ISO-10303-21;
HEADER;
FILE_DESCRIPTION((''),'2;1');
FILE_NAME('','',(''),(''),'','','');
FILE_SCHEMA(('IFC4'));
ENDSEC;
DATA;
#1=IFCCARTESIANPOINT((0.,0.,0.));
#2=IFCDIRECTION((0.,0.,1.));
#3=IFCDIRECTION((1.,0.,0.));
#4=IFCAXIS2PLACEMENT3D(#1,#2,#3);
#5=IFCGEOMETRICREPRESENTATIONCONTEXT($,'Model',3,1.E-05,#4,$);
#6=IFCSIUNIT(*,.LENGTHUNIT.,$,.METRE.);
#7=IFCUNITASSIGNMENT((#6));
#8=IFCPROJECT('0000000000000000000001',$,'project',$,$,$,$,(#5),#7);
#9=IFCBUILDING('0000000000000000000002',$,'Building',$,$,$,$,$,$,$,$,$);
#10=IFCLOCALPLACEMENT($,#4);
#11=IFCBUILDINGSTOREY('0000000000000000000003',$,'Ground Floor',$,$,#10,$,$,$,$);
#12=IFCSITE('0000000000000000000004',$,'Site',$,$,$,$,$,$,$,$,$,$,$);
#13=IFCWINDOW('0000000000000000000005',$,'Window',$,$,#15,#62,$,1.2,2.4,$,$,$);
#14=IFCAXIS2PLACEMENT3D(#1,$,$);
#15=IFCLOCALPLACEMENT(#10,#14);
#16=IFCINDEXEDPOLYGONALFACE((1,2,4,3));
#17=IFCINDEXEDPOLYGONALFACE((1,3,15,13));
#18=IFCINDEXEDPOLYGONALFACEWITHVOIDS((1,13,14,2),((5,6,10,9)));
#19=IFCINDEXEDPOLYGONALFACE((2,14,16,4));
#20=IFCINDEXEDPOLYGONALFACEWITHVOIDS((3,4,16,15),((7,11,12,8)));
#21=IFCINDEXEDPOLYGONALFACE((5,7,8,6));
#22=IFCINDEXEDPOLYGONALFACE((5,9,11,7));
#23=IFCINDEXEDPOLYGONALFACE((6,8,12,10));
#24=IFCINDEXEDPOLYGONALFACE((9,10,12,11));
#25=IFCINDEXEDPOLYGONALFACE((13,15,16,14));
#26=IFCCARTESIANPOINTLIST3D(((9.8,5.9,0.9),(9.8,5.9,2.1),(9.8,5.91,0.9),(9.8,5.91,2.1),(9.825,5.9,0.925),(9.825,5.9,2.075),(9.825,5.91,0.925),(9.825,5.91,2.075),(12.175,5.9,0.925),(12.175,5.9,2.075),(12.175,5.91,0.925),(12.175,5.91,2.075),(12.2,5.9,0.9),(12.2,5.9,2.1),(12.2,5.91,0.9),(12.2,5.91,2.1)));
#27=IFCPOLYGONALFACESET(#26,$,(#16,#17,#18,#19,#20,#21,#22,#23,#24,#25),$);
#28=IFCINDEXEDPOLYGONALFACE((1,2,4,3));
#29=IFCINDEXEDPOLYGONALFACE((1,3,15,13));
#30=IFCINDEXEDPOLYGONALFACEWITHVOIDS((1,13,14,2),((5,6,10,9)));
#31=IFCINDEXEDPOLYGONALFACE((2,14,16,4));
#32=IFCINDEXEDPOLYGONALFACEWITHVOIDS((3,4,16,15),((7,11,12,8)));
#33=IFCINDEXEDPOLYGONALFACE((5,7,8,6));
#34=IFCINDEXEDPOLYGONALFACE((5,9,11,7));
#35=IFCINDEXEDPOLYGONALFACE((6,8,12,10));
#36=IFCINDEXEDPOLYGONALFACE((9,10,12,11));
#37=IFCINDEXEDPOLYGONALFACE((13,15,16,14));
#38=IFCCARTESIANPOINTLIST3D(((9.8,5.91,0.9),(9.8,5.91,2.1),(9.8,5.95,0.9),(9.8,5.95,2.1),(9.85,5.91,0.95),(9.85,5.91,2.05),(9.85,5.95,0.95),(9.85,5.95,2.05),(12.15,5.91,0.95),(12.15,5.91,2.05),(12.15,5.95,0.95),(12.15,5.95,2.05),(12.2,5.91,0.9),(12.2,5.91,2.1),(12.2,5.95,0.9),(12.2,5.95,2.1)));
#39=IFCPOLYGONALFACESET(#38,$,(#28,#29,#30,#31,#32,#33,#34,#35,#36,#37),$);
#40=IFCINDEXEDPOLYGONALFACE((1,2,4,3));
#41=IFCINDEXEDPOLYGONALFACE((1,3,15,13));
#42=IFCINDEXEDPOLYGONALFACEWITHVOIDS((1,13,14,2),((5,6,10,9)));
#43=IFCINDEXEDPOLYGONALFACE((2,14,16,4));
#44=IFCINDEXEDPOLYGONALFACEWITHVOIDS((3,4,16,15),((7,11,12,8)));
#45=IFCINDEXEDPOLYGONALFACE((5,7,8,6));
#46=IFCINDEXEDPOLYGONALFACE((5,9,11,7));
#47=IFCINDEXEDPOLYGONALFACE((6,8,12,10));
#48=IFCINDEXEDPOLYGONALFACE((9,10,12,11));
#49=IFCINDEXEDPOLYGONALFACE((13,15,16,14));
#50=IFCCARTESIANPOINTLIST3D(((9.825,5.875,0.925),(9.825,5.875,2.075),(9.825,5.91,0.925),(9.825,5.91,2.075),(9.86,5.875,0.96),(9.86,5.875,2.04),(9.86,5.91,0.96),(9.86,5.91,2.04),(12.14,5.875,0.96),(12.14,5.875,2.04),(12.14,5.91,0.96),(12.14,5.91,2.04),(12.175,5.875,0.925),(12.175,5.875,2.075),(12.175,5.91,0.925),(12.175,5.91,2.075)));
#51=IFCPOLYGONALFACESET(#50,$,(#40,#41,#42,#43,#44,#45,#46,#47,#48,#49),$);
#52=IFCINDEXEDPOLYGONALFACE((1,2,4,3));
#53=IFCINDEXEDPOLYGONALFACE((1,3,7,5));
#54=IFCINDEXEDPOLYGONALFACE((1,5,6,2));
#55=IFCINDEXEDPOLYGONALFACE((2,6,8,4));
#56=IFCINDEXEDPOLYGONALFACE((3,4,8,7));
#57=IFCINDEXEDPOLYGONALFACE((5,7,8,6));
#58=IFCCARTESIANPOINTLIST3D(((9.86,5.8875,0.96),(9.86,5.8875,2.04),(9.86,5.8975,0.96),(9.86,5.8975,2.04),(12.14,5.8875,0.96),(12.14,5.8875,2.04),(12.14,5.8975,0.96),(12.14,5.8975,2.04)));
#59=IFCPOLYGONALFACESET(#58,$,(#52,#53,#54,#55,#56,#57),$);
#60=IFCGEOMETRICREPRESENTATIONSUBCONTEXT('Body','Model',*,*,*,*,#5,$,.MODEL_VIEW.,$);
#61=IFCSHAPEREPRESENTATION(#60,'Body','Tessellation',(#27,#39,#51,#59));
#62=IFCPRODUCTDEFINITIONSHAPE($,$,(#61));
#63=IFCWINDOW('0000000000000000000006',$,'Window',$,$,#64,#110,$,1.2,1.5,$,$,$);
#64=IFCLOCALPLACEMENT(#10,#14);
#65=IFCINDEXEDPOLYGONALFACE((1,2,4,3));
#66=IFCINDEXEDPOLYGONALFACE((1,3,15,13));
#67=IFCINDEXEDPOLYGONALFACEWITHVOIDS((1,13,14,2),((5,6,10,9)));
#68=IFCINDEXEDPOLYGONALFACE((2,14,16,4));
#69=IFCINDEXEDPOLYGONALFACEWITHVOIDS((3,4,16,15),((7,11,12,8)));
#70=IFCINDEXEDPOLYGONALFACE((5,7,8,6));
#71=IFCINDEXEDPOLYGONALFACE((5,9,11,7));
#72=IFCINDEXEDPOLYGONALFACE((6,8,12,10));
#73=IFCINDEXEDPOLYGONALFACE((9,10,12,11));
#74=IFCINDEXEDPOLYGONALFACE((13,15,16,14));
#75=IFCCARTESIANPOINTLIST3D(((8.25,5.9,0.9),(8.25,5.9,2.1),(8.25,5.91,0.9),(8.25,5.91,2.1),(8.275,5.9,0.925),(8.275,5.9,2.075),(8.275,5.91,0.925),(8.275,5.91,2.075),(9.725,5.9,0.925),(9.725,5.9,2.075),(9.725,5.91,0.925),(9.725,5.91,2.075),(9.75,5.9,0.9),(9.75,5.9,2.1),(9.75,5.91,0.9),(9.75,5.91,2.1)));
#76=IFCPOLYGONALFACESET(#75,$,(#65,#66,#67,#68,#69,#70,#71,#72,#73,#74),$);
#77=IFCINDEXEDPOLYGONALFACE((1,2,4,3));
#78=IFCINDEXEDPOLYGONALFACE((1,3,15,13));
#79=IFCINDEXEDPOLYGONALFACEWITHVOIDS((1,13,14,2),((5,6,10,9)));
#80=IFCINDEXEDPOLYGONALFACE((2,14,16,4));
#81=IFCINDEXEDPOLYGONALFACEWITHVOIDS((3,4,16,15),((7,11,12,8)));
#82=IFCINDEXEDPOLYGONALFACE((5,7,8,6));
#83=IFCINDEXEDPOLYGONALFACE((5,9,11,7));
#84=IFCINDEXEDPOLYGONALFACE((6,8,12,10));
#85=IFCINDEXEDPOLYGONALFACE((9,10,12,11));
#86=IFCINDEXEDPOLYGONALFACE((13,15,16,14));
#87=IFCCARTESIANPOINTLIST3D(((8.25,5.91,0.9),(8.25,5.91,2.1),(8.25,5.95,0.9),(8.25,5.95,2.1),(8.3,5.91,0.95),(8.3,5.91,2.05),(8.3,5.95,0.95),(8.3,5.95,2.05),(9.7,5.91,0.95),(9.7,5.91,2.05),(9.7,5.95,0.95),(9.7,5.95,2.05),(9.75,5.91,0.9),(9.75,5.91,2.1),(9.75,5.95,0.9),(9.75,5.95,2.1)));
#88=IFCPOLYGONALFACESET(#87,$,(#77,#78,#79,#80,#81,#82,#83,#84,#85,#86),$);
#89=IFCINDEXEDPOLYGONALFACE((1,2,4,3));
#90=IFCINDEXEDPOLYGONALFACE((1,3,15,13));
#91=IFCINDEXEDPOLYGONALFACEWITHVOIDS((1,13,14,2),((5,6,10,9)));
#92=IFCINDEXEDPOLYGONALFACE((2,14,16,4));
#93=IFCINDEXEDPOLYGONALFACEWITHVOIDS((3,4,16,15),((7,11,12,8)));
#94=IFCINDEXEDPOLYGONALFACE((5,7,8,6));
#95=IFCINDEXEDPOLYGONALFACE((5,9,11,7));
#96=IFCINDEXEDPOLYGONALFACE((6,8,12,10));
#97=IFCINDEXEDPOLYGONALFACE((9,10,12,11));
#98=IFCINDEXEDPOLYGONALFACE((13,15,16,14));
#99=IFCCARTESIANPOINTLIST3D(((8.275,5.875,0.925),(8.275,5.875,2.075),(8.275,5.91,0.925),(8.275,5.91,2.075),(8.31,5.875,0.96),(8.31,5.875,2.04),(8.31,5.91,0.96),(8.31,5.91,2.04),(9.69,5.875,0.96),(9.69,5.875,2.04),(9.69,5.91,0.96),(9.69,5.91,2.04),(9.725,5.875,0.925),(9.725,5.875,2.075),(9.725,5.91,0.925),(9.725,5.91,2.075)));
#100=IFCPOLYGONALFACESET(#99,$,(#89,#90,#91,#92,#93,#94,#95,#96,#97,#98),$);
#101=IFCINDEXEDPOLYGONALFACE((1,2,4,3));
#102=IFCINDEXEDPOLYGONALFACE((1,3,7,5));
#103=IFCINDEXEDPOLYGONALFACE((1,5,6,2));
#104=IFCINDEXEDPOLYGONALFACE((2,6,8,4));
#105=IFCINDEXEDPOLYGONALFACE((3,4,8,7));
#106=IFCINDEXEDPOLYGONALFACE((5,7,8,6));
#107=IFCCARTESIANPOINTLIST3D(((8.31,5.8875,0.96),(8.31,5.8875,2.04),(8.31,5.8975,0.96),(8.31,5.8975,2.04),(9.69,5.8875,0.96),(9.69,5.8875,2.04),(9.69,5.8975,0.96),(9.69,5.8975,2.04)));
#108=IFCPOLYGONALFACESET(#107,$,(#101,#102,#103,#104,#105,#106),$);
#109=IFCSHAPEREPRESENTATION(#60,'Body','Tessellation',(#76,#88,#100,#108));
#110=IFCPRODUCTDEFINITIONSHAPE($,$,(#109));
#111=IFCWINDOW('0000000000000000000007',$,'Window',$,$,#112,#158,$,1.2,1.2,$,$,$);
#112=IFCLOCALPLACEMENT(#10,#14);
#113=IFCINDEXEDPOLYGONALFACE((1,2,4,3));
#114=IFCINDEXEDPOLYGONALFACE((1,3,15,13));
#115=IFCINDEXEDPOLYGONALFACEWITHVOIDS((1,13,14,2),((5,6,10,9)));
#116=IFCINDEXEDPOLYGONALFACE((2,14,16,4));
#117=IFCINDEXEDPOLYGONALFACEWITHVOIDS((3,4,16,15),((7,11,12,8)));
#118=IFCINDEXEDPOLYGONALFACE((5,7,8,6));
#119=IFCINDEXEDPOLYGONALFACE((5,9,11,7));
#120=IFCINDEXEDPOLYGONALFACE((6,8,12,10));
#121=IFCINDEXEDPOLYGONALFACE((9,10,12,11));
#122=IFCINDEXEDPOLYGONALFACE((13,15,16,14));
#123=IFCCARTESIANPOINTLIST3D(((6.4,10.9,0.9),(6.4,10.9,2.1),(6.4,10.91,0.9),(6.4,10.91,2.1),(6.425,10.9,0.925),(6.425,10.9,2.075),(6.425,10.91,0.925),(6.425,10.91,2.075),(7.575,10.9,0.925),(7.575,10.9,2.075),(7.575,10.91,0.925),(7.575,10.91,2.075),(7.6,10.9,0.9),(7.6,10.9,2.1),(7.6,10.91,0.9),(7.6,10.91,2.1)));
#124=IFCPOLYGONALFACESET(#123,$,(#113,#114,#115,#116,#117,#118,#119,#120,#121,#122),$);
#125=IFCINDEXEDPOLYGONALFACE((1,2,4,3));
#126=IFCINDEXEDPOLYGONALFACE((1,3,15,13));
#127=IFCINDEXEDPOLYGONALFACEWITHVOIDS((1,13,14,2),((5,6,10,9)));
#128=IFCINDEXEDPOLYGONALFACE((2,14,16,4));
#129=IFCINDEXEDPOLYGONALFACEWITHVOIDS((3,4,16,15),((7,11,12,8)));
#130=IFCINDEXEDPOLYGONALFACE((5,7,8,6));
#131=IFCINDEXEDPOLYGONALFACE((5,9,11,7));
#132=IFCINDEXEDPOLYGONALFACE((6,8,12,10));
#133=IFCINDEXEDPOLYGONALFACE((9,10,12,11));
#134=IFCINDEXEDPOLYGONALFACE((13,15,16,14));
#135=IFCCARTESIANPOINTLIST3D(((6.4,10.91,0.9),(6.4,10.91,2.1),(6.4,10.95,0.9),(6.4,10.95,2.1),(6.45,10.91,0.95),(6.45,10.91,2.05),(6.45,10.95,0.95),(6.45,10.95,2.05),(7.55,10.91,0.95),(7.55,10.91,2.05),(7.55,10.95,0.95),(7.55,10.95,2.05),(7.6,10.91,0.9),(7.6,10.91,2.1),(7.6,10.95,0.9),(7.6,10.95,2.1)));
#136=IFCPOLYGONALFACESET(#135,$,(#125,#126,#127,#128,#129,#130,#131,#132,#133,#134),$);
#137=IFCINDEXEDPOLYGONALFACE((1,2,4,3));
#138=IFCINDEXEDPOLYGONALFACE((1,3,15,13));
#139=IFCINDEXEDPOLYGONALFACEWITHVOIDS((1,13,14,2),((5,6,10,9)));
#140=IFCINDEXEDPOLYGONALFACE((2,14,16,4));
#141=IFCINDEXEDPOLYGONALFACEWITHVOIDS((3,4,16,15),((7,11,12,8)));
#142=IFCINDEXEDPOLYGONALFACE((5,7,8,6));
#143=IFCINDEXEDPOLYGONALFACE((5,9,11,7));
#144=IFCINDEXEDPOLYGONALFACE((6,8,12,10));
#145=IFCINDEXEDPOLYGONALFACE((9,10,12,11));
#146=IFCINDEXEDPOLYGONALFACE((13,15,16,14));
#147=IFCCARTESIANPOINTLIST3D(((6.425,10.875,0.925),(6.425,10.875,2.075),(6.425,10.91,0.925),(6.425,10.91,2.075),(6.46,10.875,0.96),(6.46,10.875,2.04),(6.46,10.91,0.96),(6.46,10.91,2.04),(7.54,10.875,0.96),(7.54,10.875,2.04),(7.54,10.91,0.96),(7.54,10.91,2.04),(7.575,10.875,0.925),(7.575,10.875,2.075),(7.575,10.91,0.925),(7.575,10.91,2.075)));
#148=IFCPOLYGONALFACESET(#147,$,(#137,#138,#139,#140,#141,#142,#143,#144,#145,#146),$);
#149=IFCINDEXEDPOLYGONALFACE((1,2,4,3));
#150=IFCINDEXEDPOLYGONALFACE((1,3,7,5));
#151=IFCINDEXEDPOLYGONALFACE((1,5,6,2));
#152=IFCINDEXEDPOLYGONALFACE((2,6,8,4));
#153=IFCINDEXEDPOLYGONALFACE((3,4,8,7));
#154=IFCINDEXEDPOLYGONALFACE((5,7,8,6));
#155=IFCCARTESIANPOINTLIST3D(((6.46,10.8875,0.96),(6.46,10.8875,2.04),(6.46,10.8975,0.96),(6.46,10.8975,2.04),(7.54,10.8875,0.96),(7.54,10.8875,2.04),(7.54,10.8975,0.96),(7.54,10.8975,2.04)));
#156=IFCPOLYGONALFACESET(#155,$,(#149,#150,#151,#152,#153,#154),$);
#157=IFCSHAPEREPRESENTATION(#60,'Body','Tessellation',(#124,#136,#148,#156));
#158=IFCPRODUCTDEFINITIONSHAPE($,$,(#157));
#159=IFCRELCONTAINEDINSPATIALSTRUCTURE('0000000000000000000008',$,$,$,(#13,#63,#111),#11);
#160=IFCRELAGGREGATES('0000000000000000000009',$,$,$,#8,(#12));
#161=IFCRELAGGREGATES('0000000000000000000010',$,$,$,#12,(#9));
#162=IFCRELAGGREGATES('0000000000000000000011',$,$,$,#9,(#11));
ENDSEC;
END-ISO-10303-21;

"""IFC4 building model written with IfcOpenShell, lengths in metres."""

from ifc_helpers import new_model, si_unit, frame, origin_with_axes, place, context, subcontext, project, spatial, line, indexed_curve, outline, extrude, element, save


model = new_model("IFC4")

# Units and contexts
model_context = context("Model", 3, precision=1e-05, world=origin_with_axes())
body_context = subcontext(model_context, "Body", "Model", "MODEL_VIEW")
ifc_project = project(units=[si_unit("LENGTHUNIT", "METRE")], contexts=[model_context])

# Site, building, storey
site = spatial("IfcSite", under=ifc_project, Name="Site")
building = spatial("IfcBuilding", under=site, Name="Building")
storey_placement = place(None, origin_with_axes())
storey = spatial("IfcBuildingStorey", under=building, at=storey_placement, Name="Ground Floor")

# Windows
window_1_placement = place(storey_placement, frame((12.2, 6.0, 0.9), z_axis=(0.0, 0.0, 1.0), x_axis=(-1.0, 0.0, 0.0)))
element("IfcWindow", 1, at=window_1_placement, inside=storey, Name="Window", OverallHeight=1.2, OverallWidth=2.4, context=body_context, shape_type="SweptSolid", body=[
    extrude(outline(indexed_curve([(0.0, 0.0), (2.4, 0.0), (2.4, 1.2), (0.0, 1.2)], segments=[line(1, 2, 3, 4, 1)]), holes=[indexed_curve([(0.025, 0.025), (2.375, 0.025), (2.375, 1.175), (0.025, 1.175)], segments=[line(1, 2, 3, 4, 1)])]), frame((0.0, 0.09, 0.0), z_axis=(0.0, -1.0, 0.0), x_axis=(1.0, 0.0, 0.0)), (0.0, 0.0, -1.0), 0.01),
    extrude(outline(indexed_curve([(0.0, 0.0), (2.4, 0.0), (2.4, 1.2), (0.0, 1.2)], segments=[line(1, 2, 3, 4, 1)]), holes=[indexed_curve([(0.05, 0.05), (2.35, 0.05), (2.35, 1.15), (0.05, 1.15)], segments=[line(1, 2, 3, 4, 1)])]), frame((0.0, 0.05, 0.0), z_axis=(0.0, -1.0, 0.0), x_axis=(1.0, 0.0, 0.0)), (0.0, 0.0, -1.0), 0.04),
    extrude(outline(indexed_curve([(0.0, 0.0), (2.35, 0.0), (2.35, 1.15), (0.0, 1.15)], segments=[line(1, 2, 3, 4, 1)]), holes=[indexed_curve([(0.035, 0.035), (2.315, 0.035), (2.315, 1.115), (0.035, 1.115)], segments=[line(1, 2, 3, 4, 1)])]), frame((0.025, 0.09, 0.025), z_axis=(0.0, -1.0, 0.0), x_axis=(1.0, 0.0, 0.0)), (0.0, 0.0, -1.0), 0.035),
    extrude(outline(indexed_curve([(0.035, 0.035), (2.315, 0.035), (2.315, 1.115), (0.035, 1.115)], segments=[line(1, 2, 3, 4, 1)])), frame((0.025, 0.1025, 0.025), z_axis=(0.0, -1.0, 0.0), x_axis=(1.0, 0.0, 0.0)), (0.0, 0.0, -1.0), 0.01),
])
window_2_placement = place(storey_placement, frame((9.75, 6.0, 0.9), z_axis=(0.0, 0.0, 1.0), x_axis=(-1.0, 0.0, 0.0)))
element("IfcWindow", 2, at=window_2_placement, inside=storey, Name="Window", OverallHeight=1.2, OverallWidth=1.5, context=body_context, shape_type="SweptSolid", body=[
    extrude(outline(indexed_curve([(0.0, 0.0), (1.5, 0.0), (1.5, 1.2), (0.0, 1.2)], segments=[line(1, 2, 3, 4, 1)]), holes=[indexed_curve([(0.025, 0.025), (1.475, 0.025), (1.475, 1.175), (0.025, 1.175)], segments=[line(1, 2, 3, 4, 1)])]), frame((0.0, 0.09, 0.0), z_axis=(0.0, -1.0, 0.0), x_axis=(1.0, 0.0, 0.0)), (0.0, 0.0, -1.0), 0.01),
    extrude(outline(indexed_curve([(0.0, 0.0), (1.5, 0.0), (1.5, 1.2), (0.0, 1.2)], segments=[line(1, 2, 3, 4, 1)]), holes=[indexed_curve([(0.05, 0.05), (1.45, 0.05), (1.45, 1.15), (0.05, 1.15)], segments=[line(1, 2, 3, 4, 1)])]), frame((0.0, 0.05, 0.0), z_axis=(0.0, -1.0, 0.0), x_axis=(1.0, 0.0, 0.0)), (0.0, 0.0, -1.0), 0.04),
    extrude(outline(indexed_curve([(0.0, 0.0), (1.45, 0.0), (1.45, 1.15), (0.0, 1.15)], segments=[line(1, 2, 3, 4, 1)]), holes=[indexed_curve([(0.035, 0.035), (1.415, 0.035), (1.415, 1.115), (0.035, 1.115)], segments=[line(1, 2, 3, 4, 1)])]), frame((0.025, 0.09, 0.025), z_axis=(0.0, -1.0, 0.0), x_axis=(1.0, 0.0, 0.0)), (0.0, 0.0, -1.0), 0.035),
    extrude(outline(indexed_curve([(0.035, 0.035), (1.415, 0.035), (1.415, 1.115), (0.035, 1.115)], segments=[line(1, 2, 3, 4, 1)])), frame((0.025, 0.1025, 0.025), z_axis=(0.0, -1.0, 0.0), x_axis=(1.0, 0.0, 0.0)), (0.0, 0.0, -1.0), 0.01),
])
window_3_placement = place(storey_placement, frame((7.6, 11.0, 0.9), z_axis=(0.0, 0.0, 1.0), x_axis=(-1.0, 0.0, 0.0)))
element("IfcWindow", 3, at=window_3_placement, inside=storey, Name="Window", OverallHeight=1.2, OverallWidth=1.2, context=body_context, shape_type="SweptSolid", body=[
    extrude(outline(indexed_curve([(0.0, 0.0), (1.2, 0.0), (1.2, 1.2), (0.0, 1.2)], segments=[line(1, 2, 3, 4, 1)]), holes=[indexed_curve([(0.025, 0.025), (1.175, 0.025), (1.175, 1.175), (0.025, 1.175)], segments=[line(1, 2, 3, 4, 1)])]), frame((0.0, 0.09, 0.0), z_axis=(0.0, -1.0, 0.0), x_axis=(1.0, 0.0, 0.0)), (0.0, 0.0, -1.0), 0.01),
    extrude(outline(indexed_curve([(0.0, 0.0), (1.2, 0.0), (1.2, 1.2), (0.0, 1.2)], segments=[line(1, 2, 3, 4, 1)]), holes=[indexed_curve([(0.05, 0.05), (1.15, 0.05), (1.15, 1.15), (0.05, 1.15)], segments=[line(1, 2, 3, 4, 1)])]), frame((0.0, 0.05, 0.0), z_axis=(0.0, -1.0, 0.0), x_axis=(1.0, 0.0, 0.0)), (0.0, 0.0, -1.0), 0.04),
    extrude(outline(indexed_curve([(0.0, 0.0), (1.15, 0.0), (1.15, 1.15), (0.0, 1.15)], segments=[line(1, 2, 3, 4, 1)]), holes=[indexed_curve([(0.035, 0.035), (1.115, 0.035), (1.115, 1.115), (0.035, 1.115)], segments=[line(1, 2, 3, 4, 1)])]), frame((0.025, 0.09, 0.025), z_axis=(0.0, -1.0, 0.0), x_axis=(1.0, 0.0, 0.0)), (0.0, 0.0, -1.0), 0.035),
    extrude(outline(indexed_curve([(0.035, 0.035), (1.115, 0.035), (1.115, 1.115), (0.035, 1.115)], segments=[line(1, 2, 3, 4, 1)])), frame((0.025, 0.1025, 0.025), z_axis=(0.0, -1.0, 0.0), x_axis=(1.0, 0.0, 0.0)), (0.0, 0.0, -1.0), 0.01),
])

save(model, "model.ifc")
